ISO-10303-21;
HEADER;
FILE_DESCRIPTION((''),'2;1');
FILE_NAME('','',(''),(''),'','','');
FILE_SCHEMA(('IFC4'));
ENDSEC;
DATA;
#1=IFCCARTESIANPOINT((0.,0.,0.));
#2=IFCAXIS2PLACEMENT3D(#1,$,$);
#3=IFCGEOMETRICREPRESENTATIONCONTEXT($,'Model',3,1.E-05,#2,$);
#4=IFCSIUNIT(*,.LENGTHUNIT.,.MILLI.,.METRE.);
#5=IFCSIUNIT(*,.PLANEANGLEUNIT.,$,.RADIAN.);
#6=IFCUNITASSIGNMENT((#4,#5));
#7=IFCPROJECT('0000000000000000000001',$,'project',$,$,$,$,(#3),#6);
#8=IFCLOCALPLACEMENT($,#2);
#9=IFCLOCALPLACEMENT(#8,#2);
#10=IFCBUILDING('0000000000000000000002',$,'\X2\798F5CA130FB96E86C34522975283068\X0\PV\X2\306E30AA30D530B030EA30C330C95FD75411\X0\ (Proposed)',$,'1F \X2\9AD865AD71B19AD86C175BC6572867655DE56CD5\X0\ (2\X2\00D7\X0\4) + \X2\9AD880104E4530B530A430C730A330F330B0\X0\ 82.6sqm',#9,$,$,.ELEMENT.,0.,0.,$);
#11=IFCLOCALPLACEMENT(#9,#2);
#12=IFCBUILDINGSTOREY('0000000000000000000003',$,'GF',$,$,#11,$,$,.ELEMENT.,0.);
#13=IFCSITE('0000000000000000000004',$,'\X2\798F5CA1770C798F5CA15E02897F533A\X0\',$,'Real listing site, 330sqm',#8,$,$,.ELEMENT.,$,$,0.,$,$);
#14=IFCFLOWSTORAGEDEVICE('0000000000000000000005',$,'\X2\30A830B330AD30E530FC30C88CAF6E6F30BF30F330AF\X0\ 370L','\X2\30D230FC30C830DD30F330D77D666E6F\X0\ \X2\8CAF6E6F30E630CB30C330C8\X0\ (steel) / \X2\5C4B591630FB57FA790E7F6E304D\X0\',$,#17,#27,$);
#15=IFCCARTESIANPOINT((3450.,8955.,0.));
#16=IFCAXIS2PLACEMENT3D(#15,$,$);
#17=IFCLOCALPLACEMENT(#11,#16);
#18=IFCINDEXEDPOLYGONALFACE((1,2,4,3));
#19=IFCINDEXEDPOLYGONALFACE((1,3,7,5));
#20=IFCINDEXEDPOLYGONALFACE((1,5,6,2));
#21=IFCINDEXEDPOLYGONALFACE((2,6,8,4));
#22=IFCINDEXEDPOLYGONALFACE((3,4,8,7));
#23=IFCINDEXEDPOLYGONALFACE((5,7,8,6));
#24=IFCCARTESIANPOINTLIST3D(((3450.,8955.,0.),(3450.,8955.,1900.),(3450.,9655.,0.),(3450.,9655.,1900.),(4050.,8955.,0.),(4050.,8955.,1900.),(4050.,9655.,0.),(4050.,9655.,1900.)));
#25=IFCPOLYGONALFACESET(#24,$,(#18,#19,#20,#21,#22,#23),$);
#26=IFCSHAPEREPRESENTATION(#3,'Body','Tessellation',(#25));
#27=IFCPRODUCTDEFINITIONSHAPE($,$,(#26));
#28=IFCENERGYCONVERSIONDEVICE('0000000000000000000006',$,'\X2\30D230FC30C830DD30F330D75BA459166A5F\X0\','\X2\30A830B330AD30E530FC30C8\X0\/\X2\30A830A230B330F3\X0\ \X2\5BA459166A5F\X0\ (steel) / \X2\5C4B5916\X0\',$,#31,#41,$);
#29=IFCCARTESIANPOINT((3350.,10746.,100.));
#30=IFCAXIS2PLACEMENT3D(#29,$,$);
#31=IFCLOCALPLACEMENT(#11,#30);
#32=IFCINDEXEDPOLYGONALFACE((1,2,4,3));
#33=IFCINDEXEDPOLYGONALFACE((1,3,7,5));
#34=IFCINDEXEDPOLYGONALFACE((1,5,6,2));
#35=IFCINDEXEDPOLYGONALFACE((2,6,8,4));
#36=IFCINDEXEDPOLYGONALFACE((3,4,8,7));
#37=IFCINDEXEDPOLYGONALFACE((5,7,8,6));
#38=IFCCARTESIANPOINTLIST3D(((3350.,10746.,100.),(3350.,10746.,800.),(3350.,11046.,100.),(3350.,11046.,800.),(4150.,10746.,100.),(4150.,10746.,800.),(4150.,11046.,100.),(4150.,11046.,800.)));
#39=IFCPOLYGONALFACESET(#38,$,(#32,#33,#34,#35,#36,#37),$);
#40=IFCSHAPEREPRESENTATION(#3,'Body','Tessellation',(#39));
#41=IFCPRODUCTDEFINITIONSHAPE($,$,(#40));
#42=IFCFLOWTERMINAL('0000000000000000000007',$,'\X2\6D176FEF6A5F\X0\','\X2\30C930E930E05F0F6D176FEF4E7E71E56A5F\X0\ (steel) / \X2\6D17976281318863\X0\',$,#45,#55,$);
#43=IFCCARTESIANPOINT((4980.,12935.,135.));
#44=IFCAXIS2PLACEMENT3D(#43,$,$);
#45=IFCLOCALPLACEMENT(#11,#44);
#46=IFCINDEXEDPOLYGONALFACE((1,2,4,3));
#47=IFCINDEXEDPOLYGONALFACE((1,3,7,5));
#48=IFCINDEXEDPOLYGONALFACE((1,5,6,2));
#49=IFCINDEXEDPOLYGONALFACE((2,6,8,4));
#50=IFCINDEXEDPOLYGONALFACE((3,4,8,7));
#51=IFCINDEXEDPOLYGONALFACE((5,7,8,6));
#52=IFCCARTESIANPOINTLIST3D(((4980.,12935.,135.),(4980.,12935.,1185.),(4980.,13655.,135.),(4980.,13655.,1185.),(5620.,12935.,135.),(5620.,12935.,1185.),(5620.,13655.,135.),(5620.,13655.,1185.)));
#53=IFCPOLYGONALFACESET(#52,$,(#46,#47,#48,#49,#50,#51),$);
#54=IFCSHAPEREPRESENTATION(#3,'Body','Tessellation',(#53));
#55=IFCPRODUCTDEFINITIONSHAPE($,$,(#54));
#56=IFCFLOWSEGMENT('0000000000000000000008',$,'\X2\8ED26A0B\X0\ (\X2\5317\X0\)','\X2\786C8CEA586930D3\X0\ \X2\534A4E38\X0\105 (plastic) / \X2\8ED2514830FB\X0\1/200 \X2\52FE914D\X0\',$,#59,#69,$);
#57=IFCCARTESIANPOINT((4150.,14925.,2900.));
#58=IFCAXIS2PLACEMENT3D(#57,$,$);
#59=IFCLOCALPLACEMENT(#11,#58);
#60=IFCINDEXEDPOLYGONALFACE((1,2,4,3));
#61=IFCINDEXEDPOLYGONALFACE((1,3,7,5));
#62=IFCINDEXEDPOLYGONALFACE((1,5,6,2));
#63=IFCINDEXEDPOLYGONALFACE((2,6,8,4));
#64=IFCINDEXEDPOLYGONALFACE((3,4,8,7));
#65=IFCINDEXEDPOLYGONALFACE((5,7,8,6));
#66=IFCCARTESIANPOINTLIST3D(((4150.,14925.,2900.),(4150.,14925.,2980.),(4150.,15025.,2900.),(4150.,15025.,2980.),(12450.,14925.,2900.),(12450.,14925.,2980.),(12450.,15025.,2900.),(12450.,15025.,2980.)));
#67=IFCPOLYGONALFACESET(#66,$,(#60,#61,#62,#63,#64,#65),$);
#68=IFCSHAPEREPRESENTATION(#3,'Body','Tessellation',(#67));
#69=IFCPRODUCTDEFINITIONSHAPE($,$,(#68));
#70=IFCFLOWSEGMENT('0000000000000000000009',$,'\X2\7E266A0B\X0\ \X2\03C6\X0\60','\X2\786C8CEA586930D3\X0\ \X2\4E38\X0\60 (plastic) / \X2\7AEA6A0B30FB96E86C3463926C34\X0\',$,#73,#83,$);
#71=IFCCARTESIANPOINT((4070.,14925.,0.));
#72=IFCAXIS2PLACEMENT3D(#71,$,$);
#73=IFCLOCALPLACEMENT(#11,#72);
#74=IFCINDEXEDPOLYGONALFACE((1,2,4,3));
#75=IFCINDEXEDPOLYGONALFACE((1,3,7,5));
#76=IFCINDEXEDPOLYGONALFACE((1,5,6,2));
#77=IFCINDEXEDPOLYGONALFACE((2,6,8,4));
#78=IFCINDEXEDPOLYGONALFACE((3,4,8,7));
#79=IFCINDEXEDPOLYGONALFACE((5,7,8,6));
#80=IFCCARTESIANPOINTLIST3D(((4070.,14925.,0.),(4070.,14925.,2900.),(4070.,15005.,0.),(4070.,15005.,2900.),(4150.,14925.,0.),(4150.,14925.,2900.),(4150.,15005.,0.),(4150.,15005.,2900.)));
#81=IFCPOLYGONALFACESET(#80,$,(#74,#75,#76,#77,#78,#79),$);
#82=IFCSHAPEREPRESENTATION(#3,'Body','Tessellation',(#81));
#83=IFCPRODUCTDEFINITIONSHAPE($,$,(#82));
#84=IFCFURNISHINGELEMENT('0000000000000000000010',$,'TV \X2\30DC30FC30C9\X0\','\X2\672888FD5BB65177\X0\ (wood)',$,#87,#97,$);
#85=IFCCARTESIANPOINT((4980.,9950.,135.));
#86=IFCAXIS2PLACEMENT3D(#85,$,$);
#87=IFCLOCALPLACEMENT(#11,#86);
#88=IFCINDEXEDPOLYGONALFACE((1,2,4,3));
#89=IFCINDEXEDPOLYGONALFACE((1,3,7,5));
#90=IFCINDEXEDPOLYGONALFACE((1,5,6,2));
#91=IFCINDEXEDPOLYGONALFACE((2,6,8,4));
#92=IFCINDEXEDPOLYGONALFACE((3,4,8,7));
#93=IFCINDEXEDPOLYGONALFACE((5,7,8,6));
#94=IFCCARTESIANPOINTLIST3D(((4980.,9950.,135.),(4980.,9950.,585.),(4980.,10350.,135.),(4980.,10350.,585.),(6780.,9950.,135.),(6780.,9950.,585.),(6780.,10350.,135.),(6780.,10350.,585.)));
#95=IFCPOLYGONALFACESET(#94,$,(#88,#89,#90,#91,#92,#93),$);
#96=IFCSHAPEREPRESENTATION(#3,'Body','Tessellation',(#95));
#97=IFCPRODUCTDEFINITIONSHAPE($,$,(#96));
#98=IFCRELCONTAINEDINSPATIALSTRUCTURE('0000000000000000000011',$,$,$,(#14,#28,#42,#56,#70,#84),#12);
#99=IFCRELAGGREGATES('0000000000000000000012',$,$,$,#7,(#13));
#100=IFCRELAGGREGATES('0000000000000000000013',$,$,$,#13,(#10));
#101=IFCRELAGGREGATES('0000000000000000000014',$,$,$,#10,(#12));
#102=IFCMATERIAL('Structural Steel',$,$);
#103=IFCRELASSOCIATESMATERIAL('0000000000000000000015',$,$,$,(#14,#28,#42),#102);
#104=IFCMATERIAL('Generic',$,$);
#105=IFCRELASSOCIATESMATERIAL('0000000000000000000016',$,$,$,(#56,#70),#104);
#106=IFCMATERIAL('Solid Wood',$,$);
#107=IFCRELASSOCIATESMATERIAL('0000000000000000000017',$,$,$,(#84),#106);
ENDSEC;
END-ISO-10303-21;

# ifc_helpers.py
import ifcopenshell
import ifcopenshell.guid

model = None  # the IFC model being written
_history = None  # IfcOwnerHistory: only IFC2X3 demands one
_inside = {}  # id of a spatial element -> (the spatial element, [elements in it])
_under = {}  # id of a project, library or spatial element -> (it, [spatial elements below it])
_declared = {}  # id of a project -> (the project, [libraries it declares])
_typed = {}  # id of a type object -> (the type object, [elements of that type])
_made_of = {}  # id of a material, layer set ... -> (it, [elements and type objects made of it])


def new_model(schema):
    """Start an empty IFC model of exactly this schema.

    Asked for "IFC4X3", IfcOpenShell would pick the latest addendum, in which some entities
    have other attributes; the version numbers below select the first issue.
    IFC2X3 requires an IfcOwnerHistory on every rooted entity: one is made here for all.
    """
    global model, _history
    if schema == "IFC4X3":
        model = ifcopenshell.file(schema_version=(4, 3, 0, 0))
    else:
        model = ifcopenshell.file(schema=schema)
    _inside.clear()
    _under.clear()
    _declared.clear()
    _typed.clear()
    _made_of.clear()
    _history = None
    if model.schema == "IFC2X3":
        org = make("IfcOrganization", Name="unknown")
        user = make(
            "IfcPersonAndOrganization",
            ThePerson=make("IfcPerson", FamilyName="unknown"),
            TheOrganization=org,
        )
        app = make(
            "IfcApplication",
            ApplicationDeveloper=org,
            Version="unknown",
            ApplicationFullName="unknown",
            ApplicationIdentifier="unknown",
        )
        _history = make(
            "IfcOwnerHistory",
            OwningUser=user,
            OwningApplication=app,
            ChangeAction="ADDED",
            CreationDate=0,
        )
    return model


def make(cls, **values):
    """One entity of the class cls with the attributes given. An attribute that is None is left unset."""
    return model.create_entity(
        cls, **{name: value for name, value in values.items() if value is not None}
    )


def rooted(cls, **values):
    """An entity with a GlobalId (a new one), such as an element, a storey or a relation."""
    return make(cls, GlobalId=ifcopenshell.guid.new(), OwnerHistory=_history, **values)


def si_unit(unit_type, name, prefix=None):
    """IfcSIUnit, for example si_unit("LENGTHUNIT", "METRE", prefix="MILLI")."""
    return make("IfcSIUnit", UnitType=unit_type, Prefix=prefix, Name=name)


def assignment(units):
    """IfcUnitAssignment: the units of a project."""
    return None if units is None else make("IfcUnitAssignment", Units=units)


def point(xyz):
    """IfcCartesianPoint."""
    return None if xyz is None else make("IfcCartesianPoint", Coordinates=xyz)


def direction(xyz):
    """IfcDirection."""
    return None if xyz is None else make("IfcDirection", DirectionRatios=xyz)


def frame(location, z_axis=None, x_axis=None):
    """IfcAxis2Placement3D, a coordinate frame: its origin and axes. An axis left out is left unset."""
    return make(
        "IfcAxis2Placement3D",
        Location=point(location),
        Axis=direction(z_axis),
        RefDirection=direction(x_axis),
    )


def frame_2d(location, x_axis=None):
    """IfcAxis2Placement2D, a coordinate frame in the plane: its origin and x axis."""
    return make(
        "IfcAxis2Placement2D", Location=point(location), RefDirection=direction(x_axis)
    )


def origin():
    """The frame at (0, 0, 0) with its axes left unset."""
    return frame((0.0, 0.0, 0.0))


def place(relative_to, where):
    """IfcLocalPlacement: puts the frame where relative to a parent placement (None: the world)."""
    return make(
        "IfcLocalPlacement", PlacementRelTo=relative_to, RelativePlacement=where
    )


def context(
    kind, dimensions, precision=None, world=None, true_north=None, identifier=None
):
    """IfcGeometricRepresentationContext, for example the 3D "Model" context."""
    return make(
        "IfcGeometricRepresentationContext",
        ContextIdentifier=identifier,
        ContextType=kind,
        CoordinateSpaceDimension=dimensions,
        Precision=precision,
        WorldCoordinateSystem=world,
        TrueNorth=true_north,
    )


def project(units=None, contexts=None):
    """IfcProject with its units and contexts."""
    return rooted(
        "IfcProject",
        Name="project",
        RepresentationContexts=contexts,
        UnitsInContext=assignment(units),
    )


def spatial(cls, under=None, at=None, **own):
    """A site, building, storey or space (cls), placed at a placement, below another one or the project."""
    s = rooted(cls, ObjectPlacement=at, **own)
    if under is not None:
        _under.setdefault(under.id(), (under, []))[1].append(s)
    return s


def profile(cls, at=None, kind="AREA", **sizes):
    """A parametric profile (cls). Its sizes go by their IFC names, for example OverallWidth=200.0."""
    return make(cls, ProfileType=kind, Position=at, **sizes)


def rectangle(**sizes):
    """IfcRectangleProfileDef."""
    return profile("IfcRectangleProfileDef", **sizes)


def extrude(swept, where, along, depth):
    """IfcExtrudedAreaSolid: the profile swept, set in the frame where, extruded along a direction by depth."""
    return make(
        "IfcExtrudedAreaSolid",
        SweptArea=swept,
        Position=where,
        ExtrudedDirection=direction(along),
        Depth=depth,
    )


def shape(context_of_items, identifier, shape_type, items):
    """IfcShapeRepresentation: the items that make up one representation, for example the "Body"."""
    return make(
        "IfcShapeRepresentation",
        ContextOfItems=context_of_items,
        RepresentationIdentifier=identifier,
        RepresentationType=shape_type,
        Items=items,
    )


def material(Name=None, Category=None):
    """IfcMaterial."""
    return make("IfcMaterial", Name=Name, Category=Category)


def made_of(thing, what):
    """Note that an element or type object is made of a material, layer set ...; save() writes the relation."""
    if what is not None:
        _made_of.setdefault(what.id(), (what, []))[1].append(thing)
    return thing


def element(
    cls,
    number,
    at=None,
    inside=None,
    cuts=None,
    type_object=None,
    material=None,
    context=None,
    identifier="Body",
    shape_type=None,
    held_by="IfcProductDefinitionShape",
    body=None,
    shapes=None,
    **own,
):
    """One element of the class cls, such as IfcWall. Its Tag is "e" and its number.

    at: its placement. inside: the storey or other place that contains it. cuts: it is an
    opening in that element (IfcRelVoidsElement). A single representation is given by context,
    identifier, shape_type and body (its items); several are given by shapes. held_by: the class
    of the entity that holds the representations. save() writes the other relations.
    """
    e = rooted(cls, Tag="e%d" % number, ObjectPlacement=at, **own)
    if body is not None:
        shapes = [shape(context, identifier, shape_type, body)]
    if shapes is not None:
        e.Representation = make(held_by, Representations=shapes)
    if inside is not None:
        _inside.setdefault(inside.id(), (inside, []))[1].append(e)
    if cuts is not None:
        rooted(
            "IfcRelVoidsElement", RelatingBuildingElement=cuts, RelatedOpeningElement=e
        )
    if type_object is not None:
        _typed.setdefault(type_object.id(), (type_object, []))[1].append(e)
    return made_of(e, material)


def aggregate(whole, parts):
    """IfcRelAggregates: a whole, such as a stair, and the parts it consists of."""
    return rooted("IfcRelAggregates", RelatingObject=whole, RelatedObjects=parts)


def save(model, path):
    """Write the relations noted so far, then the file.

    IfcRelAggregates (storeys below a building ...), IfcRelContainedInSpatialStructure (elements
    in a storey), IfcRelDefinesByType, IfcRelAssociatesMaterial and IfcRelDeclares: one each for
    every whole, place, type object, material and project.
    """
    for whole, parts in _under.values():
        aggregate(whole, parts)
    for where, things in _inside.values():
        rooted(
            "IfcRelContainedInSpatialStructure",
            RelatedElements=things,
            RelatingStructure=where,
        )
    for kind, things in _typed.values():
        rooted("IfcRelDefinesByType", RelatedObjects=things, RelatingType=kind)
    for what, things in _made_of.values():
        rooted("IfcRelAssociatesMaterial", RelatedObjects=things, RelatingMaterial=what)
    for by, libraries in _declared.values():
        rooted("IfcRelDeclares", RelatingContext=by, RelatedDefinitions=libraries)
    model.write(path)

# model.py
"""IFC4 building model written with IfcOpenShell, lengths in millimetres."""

from ifc_helpers import new_model, si_unit, frame, frame_2d, origin, place, context, project, spatial, rectangle, extrude, material, element, save


model = new_model("IFC4")

# Units and contexts
model_context = context("Model", 3, precision=1e-05, world=origin())
ifc_project = project(units=[si_unit("LENGTHUNIT", "METRE", prefix="MILLI"), si_unit("PLANEANGLEUNIT", "RADIAN")], contexts=[model_context])

# Site, building, storey
site_placement = place(None, origin())
site = spatial("IfcSite", under=ifc_project, at=site_placement, Name="福岡県福岡市西区", ObjectType="Real listing site, 330sqm", CompositionType="ELEMENT", RefElevation=0.0)
building_placement = place(site_placement, origin())
building = spatial("IfcBuilding", under=site, at=building_placement, Name="福岡・雨水利用とPVのオフグリッド志向 (Proposed)", ObjectType="1F 高断熱高気密在来工法 (2×4) + 高耐久サイディング 82.6sqm", CompositionType="ELEMENT", ElevationOfRefHeight=0.0, ElevationOfTerrain=0.0)
storey_placement = place(building_placement, origin())
storey = spatial("IfcBuildingStorey", under=building, at=storey_placement, Name="GF", CompositionType="ELEMENT", Elevation=0.0)

# Shared definitions
ifc_material_1 = material(Name="Solid Wood")

# Shared definitions
ifc_material_2 = material(Name="Structural Steel")

# Shared definitions
ifc_material_3 = material(Name="Generic")

# Flow storage device
flow_storage_device_placement = place(storey_placement, frame((3450.0, 8955.0, 0.0)))
element("IfcFlowStorageDevice", 1, at=flow_storage_device_placement, inside=storey, material=ifc_material_2, Name="エコキュート貯湯タンク 370L", Description="ヒートポンプ給湯 貯湯ユニット (steel) / 屋外・基礎置き", context=model_context, shape_type="SweptSolid", body=[
    extrude(rectangle(XDim=600.0, YDim=700.0, at=frame_2d((300.0, 350.0))), frame((3450.0, 8955.0, 0.0)), (0.0, 0.0, 1.0), 1900.0),
])

# Energy conversion device
energy_conversion_device_placement = place(storey_placement, frame((3350.0, 10746.0, 100.0)))
element("IfcEnergyConversionDevice", 2, at=energy_conversion_device_placement, inside=storey, material=ifc_material_2, Name="ヒートポンプ室外機", Description="エコキュート/エアコン 室外機 (steel) / 屋外", context=model_context, shape_type="SweptSolid", body=[
    extrude(rectangle(XDim=800.0, YDim=300.0, at=frame_2d((400.0, 150.0))), frame((3350.0, 10746.0, 100.0)), (0.0, 0.0, 1.0), 700.0),
])

# Flow terminal
flow_terminal_placement = place(storey_placement, frame((4980.0, 12935.0, 135.0)))
element("IfcFlowTerminal", 3, at=flow_terminal_placement, inside=storey, material=ifc_material_2, Name="洗濯機", Description="ドラム式洗濯乾燥機 (steel) / 洗面脱衣", context=model_context, shape_type="SweptSolid", body=[
    extrude(rectangle(XDim=640.0, YDim=720.0, at=frame_2d((320.0, 360.0))), frame((4980.0, 12935.0, 135.0)), (0.0, 0.0, 1.0), 1050.0),
])

# Flow segments
flow_segment_1_placement = place(storey_placement, frame((4150.0, 14925.0, 2900.0)))
element("IfcFlowSegment", 4, at=flow_segment_1_placement, inside=storey, material=ifc_material_3, Name="軒樋 (北)", Description="硬質塩ビ 半丸105 (plastic) / 軒先・1/200 勾配", context=model_context, shape_type="SweptSolid", body=[
    extrude(rectangle(XDim=8300.0, YDim=100.0, at=frame_2d((4150.0, 50.0))), frame((4150.0, 14925.0, 2900.0)), (0.0, 0.0, 1.0), 80.0),
])
flow_segment_2_placement = place(storey_placement, frame((4070.0, 14925.0, 0.0)))
element("IfcFlowSegment", 5, at=flow_segment_2_placement, inside=storey, material=ifc_material_3, Name="縦樋 φ60", Description="硬質塩ビ 丸60 (plastic) / 竪樋・雨水排水", context=model_context, shape_type="SweptSolid", body=[
    extrude(rectangle(XDim=80.0, YDim=80.0, at=frame_2d((40.0, 40.0))), frame((4070.0, 14925.0, 0.0)), (0.0, 0.0, 1.0), 2900.0),
])

# Furnishing element
furnishing_placement = place(storey_placement, frame((4980.0, 9950.0, 135.0)))
element("IfcFurnishingElement", 6, at=furnishing_placement, inside=storey, material=ifc_material_1, Name="TV ボード", Description="木製家具 (wood)", context=model_context, shape_type="SweptSolid", body=[
    extrude(rectangle(XDim=1800.0, YDim=400.0, at=frame_2d((900.0, 200.0))), frame((4980.0, 9950.0, 135.0)), (0.0, 0.0, 1.0), 450.0),
])

save(model, "model.ifc")
